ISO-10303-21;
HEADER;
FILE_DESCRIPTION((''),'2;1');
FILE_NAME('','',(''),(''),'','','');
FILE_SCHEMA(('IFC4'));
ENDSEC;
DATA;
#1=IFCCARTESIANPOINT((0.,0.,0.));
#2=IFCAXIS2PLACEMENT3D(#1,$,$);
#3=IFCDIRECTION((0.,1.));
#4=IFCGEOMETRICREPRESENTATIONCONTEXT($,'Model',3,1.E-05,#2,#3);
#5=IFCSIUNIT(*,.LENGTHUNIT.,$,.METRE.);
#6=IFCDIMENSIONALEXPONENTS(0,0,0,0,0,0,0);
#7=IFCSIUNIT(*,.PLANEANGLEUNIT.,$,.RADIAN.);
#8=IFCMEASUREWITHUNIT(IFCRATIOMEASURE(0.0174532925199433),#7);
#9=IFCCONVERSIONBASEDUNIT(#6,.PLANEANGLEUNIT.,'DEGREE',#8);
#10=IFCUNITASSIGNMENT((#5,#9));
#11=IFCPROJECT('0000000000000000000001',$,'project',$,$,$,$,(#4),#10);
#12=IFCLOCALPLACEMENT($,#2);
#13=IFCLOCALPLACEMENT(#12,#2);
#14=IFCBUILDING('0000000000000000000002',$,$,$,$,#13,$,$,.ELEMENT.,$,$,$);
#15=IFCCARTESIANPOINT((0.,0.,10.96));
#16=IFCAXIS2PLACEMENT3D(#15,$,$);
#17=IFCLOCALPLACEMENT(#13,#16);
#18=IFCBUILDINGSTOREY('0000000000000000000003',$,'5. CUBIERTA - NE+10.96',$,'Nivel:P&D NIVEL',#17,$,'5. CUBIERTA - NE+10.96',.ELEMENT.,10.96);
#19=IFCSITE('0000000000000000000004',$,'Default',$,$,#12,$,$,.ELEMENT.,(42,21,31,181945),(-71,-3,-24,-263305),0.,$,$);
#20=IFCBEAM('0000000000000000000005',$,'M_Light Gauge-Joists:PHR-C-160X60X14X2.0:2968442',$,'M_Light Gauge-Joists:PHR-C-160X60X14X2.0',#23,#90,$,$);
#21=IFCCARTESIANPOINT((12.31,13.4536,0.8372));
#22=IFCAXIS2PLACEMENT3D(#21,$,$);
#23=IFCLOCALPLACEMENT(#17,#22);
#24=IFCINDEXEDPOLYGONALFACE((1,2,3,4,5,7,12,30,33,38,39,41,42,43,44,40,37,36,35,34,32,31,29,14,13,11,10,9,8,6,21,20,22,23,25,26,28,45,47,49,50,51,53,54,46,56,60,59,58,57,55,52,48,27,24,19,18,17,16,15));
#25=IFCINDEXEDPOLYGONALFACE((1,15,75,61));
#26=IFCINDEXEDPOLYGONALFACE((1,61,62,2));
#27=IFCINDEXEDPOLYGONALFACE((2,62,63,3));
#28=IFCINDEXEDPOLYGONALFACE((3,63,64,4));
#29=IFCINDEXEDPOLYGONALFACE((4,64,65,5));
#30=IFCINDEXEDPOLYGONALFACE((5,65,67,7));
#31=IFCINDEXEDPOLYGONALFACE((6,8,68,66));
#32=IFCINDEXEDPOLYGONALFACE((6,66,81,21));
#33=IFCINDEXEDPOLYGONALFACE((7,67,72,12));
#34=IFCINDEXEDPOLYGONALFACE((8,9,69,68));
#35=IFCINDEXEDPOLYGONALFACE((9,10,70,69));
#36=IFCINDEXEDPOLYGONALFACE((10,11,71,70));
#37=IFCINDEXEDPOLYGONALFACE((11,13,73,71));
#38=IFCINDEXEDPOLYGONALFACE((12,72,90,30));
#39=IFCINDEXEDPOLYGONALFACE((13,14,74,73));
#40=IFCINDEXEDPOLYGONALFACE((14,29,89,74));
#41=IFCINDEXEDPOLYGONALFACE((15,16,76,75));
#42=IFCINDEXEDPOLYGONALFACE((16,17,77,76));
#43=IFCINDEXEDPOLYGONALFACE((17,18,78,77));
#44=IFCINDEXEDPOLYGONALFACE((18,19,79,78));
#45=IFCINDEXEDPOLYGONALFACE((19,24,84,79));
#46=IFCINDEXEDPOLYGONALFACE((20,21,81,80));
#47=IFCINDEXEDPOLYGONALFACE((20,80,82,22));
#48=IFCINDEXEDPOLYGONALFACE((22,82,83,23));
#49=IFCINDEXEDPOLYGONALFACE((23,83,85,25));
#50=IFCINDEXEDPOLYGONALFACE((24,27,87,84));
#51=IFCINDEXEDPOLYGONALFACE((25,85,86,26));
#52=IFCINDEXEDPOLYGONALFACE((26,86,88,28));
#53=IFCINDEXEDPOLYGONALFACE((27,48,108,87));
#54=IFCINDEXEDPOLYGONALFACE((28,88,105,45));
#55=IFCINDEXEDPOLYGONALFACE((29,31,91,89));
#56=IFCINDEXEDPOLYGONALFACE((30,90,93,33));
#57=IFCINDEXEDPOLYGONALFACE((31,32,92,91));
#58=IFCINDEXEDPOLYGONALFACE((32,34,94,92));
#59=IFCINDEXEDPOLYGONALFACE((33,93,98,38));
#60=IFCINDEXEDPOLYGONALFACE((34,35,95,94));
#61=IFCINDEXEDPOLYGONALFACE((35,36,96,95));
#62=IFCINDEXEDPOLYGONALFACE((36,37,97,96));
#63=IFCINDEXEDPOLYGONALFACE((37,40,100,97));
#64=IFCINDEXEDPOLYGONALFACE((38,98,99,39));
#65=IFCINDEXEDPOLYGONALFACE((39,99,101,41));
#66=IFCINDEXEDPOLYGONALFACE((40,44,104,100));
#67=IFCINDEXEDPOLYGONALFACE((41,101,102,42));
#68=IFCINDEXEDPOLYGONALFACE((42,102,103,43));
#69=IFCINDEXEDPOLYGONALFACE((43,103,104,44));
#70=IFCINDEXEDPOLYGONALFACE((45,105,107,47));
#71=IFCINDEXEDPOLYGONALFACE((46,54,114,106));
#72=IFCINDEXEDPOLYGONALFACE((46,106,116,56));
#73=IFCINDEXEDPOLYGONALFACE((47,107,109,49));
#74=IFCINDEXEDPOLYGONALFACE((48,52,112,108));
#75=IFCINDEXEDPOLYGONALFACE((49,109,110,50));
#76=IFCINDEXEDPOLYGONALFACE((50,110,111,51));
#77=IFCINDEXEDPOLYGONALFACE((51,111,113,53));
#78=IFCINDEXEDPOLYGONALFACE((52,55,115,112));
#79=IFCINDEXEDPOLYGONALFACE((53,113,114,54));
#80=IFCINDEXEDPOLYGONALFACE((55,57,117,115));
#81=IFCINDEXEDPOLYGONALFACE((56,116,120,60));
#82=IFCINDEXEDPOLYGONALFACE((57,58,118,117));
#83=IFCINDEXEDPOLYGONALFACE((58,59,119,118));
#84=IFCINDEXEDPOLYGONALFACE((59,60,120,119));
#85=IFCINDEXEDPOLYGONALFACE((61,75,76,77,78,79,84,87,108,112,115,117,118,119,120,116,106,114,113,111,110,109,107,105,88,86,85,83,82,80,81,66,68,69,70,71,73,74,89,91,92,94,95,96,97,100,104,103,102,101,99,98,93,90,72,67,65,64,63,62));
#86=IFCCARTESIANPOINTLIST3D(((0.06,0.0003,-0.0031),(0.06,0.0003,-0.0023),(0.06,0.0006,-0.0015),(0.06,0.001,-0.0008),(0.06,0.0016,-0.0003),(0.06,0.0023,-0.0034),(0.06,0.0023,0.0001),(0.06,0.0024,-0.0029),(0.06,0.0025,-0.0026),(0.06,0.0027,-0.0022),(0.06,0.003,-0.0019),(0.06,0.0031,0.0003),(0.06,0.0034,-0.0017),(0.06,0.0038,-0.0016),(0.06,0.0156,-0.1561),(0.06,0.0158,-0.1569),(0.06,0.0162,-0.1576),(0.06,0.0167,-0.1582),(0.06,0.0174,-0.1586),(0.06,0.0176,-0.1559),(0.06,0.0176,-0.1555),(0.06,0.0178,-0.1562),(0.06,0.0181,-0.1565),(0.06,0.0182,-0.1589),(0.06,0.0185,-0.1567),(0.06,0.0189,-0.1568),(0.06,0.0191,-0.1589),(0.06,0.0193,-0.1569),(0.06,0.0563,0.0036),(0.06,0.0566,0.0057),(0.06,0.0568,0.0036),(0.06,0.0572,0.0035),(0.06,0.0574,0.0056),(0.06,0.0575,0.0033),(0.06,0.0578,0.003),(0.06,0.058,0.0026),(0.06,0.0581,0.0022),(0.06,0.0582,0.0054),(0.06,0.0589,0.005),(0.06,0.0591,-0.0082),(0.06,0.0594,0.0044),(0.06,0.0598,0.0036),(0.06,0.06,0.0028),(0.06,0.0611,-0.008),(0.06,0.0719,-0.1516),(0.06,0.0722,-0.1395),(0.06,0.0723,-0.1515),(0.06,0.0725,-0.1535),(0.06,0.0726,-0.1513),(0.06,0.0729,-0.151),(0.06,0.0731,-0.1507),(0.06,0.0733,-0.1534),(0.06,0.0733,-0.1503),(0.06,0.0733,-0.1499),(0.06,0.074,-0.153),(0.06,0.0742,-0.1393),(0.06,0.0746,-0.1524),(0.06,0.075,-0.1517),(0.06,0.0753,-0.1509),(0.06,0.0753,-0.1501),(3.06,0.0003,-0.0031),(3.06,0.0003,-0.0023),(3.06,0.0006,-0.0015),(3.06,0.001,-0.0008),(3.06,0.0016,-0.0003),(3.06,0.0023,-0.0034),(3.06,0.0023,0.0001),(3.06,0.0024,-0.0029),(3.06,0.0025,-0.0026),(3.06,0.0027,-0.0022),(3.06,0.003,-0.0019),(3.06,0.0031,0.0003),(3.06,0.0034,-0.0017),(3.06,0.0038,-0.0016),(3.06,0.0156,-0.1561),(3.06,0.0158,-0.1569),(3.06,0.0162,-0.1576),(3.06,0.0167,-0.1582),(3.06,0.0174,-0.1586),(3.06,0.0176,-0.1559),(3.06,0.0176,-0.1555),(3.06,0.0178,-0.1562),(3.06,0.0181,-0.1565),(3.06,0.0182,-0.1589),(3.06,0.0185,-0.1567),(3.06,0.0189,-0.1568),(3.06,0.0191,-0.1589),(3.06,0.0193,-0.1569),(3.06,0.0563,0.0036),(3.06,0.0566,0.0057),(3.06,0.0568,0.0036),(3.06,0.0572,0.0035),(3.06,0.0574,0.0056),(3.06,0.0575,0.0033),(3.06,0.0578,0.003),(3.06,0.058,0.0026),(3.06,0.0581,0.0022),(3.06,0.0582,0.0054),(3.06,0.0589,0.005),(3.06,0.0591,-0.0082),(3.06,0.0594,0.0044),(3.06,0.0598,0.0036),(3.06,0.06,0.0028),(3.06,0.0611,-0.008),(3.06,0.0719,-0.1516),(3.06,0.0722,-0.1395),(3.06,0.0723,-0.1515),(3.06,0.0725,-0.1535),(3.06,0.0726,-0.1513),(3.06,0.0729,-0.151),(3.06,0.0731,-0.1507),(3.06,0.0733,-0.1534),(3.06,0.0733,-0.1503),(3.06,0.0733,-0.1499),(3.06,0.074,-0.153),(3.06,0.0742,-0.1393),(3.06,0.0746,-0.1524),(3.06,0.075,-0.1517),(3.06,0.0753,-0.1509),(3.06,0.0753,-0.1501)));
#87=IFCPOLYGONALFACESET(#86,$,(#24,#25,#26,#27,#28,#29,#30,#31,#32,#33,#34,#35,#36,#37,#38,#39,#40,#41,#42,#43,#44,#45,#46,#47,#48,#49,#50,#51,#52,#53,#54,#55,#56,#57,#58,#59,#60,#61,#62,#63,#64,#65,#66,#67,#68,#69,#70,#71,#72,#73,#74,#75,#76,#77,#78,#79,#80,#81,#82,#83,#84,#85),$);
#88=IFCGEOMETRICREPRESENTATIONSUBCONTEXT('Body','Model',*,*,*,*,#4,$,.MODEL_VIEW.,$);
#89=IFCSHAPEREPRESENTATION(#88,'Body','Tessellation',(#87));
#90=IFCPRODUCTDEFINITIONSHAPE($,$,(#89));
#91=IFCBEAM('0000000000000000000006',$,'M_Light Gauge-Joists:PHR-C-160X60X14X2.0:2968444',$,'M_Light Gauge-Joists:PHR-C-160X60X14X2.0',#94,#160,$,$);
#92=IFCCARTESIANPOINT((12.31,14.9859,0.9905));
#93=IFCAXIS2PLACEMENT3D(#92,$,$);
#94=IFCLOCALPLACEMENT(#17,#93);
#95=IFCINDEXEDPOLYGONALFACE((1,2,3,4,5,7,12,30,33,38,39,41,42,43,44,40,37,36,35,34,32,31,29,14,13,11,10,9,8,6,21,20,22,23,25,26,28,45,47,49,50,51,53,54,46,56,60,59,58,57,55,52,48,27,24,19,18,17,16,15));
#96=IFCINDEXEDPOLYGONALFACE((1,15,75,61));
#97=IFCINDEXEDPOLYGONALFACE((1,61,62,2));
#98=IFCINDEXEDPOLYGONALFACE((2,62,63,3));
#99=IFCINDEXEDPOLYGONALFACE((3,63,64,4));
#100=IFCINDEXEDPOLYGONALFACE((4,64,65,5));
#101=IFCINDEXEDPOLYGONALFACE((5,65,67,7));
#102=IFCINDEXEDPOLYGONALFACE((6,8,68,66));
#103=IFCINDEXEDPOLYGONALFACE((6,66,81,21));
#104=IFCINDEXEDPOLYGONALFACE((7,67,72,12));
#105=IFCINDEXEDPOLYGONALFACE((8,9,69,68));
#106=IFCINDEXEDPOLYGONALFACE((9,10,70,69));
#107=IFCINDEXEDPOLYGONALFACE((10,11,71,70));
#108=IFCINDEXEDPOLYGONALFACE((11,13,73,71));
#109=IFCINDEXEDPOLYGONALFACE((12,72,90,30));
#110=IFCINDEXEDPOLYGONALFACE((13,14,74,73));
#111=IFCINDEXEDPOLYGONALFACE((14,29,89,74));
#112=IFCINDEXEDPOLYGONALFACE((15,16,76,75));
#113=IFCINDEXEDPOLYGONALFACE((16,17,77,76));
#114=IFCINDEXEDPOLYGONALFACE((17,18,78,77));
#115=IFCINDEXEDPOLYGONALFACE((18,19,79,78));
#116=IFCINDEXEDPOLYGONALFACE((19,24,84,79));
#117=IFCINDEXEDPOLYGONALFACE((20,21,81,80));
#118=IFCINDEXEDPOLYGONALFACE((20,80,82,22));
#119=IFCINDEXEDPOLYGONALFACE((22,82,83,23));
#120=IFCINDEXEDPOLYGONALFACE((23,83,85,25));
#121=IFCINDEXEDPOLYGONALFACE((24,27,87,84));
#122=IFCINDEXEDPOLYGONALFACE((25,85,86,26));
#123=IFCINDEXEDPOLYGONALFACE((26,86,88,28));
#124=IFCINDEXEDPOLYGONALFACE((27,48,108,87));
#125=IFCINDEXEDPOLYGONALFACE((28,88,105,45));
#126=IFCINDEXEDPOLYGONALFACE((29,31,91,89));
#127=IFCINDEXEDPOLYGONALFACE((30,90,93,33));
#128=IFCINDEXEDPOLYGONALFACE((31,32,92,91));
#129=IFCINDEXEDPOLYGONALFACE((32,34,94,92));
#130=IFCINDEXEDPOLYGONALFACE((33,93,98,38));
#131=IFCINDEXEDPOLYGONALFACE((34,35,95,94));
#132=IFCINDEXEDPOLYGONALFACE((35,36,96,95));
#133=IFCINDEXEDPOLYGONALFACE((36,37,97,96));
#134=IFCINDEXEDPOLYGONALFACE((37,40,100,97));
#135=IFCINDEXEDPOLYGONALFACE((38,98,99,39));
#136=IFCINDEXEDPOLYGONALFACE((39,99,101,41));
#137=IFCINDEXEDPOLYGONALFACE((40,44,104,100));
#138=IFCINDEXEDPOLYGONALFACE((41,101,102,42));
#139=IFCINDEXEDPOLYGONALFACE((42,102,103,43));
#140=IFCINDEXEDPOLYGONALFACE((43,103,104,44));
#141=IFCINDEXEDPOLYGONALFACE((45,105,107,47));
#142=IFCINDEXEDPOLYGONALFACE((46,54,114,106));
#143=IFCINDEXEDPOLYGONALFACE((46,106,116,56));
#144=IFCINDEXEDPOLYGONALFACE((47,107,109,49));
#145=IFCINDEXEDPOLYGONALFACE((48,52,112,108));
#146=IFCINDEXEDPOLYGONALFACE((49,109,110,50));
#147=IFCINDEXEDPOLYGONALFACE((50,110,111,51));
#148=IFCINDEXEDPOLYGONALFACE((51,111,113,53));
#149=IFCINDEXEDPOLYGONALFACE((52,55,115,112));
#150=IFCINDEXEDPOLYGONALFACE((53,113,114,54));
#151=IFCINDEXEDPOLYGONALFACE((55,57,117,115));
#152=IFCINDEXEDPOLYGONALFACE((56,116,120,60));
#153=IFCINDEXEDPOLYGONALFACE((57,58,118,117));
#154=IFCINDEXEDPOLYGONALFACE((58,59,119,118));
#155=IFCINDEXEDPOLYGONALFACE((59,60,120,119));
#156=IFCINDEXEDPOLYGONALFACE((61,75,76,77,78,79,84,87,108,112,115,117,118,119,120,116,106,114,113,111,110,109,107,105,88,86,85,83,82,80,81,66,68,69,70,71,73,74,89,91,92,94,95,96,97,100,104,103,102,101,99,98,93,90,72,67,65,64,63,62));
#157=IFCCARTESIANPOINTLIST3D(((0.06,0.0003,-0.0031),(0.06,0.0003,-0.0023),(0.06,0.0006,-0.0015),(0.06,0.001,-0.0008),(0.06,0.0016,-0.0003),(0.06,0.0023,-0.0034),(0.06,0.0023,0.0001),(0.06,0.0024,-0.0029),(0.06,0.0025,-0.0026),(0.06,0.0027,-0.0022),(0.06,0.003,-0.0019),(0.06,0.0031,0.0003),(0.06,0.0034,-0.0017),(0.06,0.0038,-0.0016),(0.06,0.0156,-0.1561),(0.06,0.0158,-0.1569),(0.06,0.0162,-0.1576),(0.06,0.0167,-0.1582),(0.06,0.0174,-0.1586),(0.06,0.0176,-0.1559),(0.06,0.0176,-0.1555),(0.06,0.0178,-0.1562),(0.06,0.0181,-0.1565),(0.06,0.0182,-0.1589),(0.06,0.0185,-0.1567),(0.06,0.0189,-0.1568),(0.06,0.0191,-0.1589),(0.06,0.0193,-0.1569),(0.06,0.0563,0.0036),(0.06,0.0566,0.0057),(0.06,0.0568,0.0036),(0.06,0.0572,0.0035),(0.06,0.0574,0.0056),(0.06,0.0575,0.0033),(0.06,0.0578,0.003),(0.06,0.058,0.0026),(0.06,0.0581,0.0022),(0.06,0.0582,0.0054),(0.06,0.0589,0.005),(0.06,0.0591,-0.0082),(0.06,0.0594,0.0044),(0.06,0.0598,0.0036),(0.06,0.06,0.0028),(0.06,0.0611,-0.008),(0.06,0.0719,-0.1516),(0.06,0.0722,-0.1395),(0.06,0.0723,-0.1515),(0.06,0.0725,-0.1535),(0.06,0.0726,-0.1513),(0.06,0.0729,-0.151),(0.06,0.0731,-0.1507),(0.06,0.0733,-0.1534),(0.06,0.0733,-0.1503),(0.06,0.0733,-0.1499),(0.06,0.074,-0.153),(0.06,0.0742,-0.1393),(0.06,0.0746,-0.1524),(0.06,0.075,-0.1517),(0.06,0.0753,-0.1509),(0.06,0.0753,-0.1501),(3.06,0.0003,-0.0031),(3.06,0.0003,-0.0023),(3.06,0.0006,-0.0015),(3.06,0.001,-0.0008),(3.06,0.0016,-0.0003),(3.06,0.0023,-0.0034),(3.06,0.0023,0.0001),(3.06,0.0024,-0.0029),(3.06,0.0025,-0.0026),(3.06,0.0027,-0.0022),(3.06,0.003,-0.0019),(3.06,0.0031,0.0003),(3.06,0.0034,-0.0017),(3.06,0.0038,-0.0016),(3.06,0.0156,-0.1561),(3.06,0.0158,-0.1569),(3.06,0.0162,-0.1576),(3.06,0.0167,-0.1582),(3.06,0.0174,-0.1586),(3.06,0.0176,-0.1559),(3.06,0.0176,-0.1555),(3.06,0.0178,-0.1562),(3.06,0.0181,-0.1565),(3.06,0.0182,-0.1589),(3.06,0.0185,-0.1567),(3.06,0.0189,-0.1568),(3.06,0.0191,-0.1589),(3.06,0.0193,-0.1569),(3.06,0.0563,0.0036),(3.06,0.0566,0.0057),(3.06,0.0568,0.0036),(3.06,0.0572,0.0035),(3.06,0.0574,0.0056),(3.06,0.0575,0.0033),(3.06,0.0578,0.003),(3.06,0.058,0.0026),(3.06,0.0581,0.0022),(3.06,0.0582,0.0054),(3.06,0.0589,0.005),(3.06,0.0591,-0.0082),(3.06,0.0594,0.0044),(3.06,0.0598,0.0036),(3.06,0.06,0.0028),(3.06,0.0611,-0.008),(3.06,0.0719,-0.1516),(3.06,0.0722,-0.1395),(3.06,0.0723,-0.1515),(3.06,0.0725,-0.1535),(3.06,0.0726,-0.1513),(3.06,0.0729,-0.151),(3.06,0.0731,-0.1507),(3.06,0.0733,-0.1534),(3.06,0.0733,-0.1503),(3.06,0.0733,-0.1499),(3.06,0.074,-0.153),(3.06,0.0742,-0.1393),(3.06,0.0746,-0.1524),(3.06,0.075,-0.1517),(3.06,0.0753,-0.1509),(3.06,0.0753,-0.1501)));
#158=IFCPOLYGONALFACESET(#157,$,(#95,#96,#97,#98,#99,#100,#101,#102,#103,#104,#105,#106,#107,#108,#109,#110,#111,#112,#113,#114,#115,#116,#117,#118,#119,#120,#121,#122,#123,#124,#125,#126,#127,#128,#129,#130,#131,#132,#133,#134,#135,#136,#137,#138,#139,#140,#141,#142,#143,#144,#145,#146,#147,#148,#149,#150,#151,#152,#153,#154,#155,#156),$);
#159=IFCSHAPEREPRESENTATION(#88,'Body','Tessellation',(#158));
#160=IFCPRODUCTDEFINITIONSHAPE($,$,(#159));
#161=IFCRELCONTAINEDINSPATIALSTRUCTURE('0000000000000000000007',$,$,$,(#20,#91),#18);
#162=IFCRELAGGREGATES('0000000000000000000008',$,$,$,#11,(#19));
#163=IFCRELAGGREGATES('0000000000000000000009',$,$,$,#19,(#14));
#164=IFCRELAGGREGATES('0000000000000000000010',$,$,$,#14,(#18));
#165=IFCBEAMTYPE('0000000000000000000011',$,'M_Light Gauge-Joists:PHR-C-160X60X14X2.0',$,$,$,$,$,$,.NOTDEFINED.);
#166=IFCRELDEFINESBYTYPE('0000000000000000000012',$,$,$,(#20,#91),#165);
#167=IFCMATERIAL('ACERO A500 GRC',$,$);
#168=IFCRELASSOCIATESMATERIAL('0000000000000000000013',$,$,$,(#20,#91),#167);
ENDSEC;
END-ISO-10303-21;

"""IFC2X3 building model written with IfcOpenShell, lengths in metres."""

from ifc_helpers import new_model, entity, si_unit, converted_unit, direction, frame, frame_2d, origin, place, context, subcontext, project, spatial, polyline, circle_curve, parameter, trimmed, segment, composite_curve, outline, extrude, material, type_object, element, save


model = new_model("IFC2X3")

# Units and contexts
model_context = context("Model", 3, precision=1e-05, world=origin(), true_north=direction((0.0, 1.0)))
body_context = subcontext(model_context, "Body", "Model", "MODEL_VIEW")
ifc_project = project(units=[si_unit("LENGTHUNIT", "METRE"), converted_unit("PLANEANGLEUNIT", "DEGREE", entity("IfcRatioMeasure", 0.0174532925199433), si_unit("PLANEANGLEUNIT", "RADIAN"), dimensions=[0, 0, 0, 0, 0, 0, 0])], contexts=[model_context])

# Site, building, storey
site_placement = place(None, origin())
site = spatial("IfcSite", under=ifc_project, at=site_placement, Name="Default", CompositionType="ELEMENT", RefLatitude=(42, 21, 31, 181945), RefLongitude=(-71, -3, -24, -263305), RefElevation=0.0)
building_placement = place(site_placement, origin())
building = spatial("IfcBuilding", under=site, at=building_placement, CompositionType="ELEMENT")
storey_placement = place(building_placement, frame((0.0, 0.0, 10.96)))
storey = spatial("IfcBuildingStorey", under=building, at=storey_placement, Name="5. CUBIERTA - NE+10.96", ObjectType="Nivel:P&D NIVEL", LongName="5. CUBIERTA - NE+10.96", CompositionType="ELEMENT", Elevation=10.96)

# Beams
ifc_material_1 = material(Name="ACERO A500 GRC")
beam_type_1 = type_object("IfcBeamType", Name="M_Light Gauge-Joists:PHR-C-160X60X14X2.0", PredefinedType="NOTDEFINED")
beam_1_placement = place(storey_placement, frame((12.31, 13.4536, 0.8372)))
element("IfcBeam", 1, at=beam_1_placement, inside=storey, type_object=beam_type_1, material=ifc_material_1, Name="M_Light Gauge-Joists:PHR-C-160X60X14X2.0:2968442", ObjectType="M_Light Gauge-Joists:PHR-C-160X60X14X2.0", context=body_context, shape_type="SweptSolid", body=[
    extrude(outline(composite_curve([segment(trimmed(circle_curve(frame_2d((-0.0764, -0.0322), x_axis=(-1.0, 0.0)), 0.0016), [parameter(0.0)], [parameter(90.0)], True, "PARAMETER"), False, "CONTINUOUS"), segment(polyline([(-0.078, -0.0322), (-0.078, 0.0206)]), True, "CONTINUOUS"), segment(trimmed(circle_curve(frame_2d((-0.0764, 0.0206), x_axis=(0.0, 1.0)), 0.0016), [parameter(0.0)], [parameter(90.0)], True, "PARAMETER"), False, "CONTINUOUS"), segment(polyline([(-0.0764, 0.0222), (-0.066, 0.0222)]), True, "CONTINUOUS"), segment(polyline([(-0.066, 0.0222), (-0.066, 0.0242)]), True, "CONTINUOUS"), segment(polyline([(-0.066, 0.0242), (-0.0768, 0.0242)]), True, "CONTINUOUS"), segment(trimmed(circle_curve(frame_2d((-0.0768, 0.021), x_axis=(-1.0, 0.0)), 0.0032), [parameter(270.0)], [parameter(0.0)], True, "PARAMETER"), True, "CONTINUOUS"), segment(polyline([(-0.08, 0.021), (-0.08, -0.0326)]), True, "CONTINUOUS"), segment(trimmed(circle_curve(frame_2d((-0.0768, -0.0326), x_axis=(0.0, -1.0)), 0.0032), [parameter(270.0)], [parameter(0.0)], True, "PARAMETER"), True, "CONTINUOUS"), segment(polyline([(-0.0768, -0.0358), (0.0768, -0.0358)]), True, "CONTINUOUS"), segment(trimmed(circle_curve(frame_2d((0.0768, -0.0326), x_axis=(1.0, 0.0)), 0.0032), [parameter(270.0)], [parameter(0.0)], True, "PARAMETER"), True, "CONTINUOUS"), segment(polyline([(0.08, -0.0326), (0.08, 0.021)]), True, "CONTINUOUS"), segment(trimmed(circle_curve(frame_2d((0.0768, 0.021), x_axis=(0.0, 1.0)), 0.0032), [parameter(270.0)], [parameter(0.0)], True, "PARAMETER"), True, "CONTINUOUS"), segment(polyline([(0.0768, 0.0242), (0.066, 0.0242)]), True, "CONTINUOUS"), segment(polyline([(0.066, 0.0242), (0.066, 0.0222)]), True, "CONTINUOUS"), segment(polyline([(0.066, 0.0222), (0.0764, 0.0222)]), True, "CONTINUOUS"), segment(trimmed(circle_curve(frame_2d((0.0764, 0.0206), x_axis=(1.0, 0.0)), 0.0016), [parameter(0.0)], [parameter(90.0)], True, "PARAMETER"), False, "CONTINUOUS"), segment(polyline([(0.078, 0.0206), (0.078, -0.0322)]), True, "CONTINUOUS"), segment(trimmed(circle_curve(frame_2d((0.0764, -0.0322), x_axis=(0.0, -1.0)), 0.0016), [parameter(0.0)], [parameter(90.0)], True, "PARAMETER"), False, "CONTINUOUS"), segment(polyline([(0.0764, -0.0338), (-0.0764, -0.0338)]), True, "CONTINUOUS")], self_intersect=False)), frame((0.06, 0.0436, -0.076), z_axis=(-1.0, 0.0, 0.0), x_axis=(0.0, -0.099504, 0.995037)), (0.0, 0.0, -1.0), 3.0),
])
beam_2_placement = place(storey_placement, frame((12.31, 14.9859, 0.9905)))
element("IfcBeam", 2, at=beam_2_placement, inside=storey, type_object=beam_type_1, material=ifc_material_1, Name="M_Light Gauge-Joists:PHR-C-160X60X14X2.0:2968444", ObjectType="M_Light Gauge-Joists:PHR-C-160X60X14X2.0", context=body_context, shape_type="SweptSolid", body=[
    extrude(outline(composite_curve([segment(trimmed(circle_curve(frame_2d((-0.0764, -0.0322), x_axis=(-1.0, 0.0)), 0.0016), [parameter(0.0)], [parameter(90.0)], True, "PARAMETER"), False, "CONTINUOUS"), segment(polyline([(-0.078, -0.0322), (-0.078, 0.0206)]), True, "CONTINUOUS"), segment(trimmed(circle_curve(frame_2d((-0.0764, 0.0206), x_axis=(0.0, 1.0)), 0.0016), [parameter(0.0)], [parameter(90.0)], True, "PARAMETER"), False, "CONTINUOUS"), segment(polyline([(-0.0764, 0.0222), (-0.066, 0.0222)]), True, "CONTINUOUS"), segment(polyline([(-0.066, 0.0222), (-0.066, 0.0242)]), True, "CONTINUOUS"), segment(polyline([(-0.066, 0.0242), (-0.0768, 0.0242)]), True, "CONTINUOUS"), segment(trimmed(circle_curve(frame_2d((-0.0768, 0.021), x_axis=(-1.0, 0.0)), 0.0032), [parameter(270.0)], [parameter(0.0)], True, "PARAMETER"), True, "CONTINUOUS"), segment(polyline([(-0.08, 0.021), (-0.08, -0.0326)]), True, "CONTINUOUS"), segment(trimmed(circle_curve(frame_2d((-0.0768, -0.0326), x_axis=(0.0, -1.0)), 0.0032), [parameter(270.0)], [parameter(0.0)], True, "PARAMETER"), True, "CONTINUOUS"), segment(polyline([(-0.0768, -0.0358), (0.0768, -0.0358)]), True, "CONTINUOUS"), segment(trimmed(circle_curve(frame_2d((0.0768, -0.0326), x_axis=(1.0, 0.0)), 0.0032), [parameter(270.0)], [parameter(0.0)], True, "PARAMETER"), True, "CONTINUOUS"), segment(polyline([(0.08, -0.0326), (0.08, 0.021)]), True, "CONTINUOUS"), segment(trimmed(circle_curve(frame_2d((0.0768, 0.021), x_axis=(0.0, 1.0)), 0.0032), [parameter(270.0)], [parameter(0.0)], True, "PARAMETER"), True, "CONTINUOUS"), segment(polyline([(0.0768, 0.0242), (0.066, 0.0242)]), True, "CONTINUOUS"), segment(polyline([(0.066, 0.0242), (0.066, 0.0222)]), True, "CONTINUOUS"), segment(polyline([(0.066, 0.0222), (0.0764, 0.0222)]), True, "CONTINUOUS"), segment(trimmed(circle_curve(frame_2d((0.0764, 0.0206), x_axis=(1.0, 0.0)), 0.0016), [parameter(0.0)], [parameter(90.0)], True, "PARAMETER"), False, "CONTINUOUS"), segment(polyline([(0.078, 0.0206), (0.078, -0.0322)]), True, "CONTINUOUS"), segment(trimmed(circle_curve(frame_2d((0.0764, -0.0322), x_axis=(0.0, -1.0)), 0.0016), [parameter(0.0)], [parameter(90.0)], True, "PARAMETER"), False, "CONTINUOUS"), segment(polyline([(0.0764, -0.0338), (-0.0764, -0.0338)]), True, "CONTINUOUS")], self_intersect=False)), frame((0.06, 0.0436, -0.076), z_axis=(-1.0, 0.0, 0.0), x_axis=(0.0, -0.099504, 0.995037)), (0.0, 0.0, -1.0), 3.0),
])

save(model, "model.ifc")
